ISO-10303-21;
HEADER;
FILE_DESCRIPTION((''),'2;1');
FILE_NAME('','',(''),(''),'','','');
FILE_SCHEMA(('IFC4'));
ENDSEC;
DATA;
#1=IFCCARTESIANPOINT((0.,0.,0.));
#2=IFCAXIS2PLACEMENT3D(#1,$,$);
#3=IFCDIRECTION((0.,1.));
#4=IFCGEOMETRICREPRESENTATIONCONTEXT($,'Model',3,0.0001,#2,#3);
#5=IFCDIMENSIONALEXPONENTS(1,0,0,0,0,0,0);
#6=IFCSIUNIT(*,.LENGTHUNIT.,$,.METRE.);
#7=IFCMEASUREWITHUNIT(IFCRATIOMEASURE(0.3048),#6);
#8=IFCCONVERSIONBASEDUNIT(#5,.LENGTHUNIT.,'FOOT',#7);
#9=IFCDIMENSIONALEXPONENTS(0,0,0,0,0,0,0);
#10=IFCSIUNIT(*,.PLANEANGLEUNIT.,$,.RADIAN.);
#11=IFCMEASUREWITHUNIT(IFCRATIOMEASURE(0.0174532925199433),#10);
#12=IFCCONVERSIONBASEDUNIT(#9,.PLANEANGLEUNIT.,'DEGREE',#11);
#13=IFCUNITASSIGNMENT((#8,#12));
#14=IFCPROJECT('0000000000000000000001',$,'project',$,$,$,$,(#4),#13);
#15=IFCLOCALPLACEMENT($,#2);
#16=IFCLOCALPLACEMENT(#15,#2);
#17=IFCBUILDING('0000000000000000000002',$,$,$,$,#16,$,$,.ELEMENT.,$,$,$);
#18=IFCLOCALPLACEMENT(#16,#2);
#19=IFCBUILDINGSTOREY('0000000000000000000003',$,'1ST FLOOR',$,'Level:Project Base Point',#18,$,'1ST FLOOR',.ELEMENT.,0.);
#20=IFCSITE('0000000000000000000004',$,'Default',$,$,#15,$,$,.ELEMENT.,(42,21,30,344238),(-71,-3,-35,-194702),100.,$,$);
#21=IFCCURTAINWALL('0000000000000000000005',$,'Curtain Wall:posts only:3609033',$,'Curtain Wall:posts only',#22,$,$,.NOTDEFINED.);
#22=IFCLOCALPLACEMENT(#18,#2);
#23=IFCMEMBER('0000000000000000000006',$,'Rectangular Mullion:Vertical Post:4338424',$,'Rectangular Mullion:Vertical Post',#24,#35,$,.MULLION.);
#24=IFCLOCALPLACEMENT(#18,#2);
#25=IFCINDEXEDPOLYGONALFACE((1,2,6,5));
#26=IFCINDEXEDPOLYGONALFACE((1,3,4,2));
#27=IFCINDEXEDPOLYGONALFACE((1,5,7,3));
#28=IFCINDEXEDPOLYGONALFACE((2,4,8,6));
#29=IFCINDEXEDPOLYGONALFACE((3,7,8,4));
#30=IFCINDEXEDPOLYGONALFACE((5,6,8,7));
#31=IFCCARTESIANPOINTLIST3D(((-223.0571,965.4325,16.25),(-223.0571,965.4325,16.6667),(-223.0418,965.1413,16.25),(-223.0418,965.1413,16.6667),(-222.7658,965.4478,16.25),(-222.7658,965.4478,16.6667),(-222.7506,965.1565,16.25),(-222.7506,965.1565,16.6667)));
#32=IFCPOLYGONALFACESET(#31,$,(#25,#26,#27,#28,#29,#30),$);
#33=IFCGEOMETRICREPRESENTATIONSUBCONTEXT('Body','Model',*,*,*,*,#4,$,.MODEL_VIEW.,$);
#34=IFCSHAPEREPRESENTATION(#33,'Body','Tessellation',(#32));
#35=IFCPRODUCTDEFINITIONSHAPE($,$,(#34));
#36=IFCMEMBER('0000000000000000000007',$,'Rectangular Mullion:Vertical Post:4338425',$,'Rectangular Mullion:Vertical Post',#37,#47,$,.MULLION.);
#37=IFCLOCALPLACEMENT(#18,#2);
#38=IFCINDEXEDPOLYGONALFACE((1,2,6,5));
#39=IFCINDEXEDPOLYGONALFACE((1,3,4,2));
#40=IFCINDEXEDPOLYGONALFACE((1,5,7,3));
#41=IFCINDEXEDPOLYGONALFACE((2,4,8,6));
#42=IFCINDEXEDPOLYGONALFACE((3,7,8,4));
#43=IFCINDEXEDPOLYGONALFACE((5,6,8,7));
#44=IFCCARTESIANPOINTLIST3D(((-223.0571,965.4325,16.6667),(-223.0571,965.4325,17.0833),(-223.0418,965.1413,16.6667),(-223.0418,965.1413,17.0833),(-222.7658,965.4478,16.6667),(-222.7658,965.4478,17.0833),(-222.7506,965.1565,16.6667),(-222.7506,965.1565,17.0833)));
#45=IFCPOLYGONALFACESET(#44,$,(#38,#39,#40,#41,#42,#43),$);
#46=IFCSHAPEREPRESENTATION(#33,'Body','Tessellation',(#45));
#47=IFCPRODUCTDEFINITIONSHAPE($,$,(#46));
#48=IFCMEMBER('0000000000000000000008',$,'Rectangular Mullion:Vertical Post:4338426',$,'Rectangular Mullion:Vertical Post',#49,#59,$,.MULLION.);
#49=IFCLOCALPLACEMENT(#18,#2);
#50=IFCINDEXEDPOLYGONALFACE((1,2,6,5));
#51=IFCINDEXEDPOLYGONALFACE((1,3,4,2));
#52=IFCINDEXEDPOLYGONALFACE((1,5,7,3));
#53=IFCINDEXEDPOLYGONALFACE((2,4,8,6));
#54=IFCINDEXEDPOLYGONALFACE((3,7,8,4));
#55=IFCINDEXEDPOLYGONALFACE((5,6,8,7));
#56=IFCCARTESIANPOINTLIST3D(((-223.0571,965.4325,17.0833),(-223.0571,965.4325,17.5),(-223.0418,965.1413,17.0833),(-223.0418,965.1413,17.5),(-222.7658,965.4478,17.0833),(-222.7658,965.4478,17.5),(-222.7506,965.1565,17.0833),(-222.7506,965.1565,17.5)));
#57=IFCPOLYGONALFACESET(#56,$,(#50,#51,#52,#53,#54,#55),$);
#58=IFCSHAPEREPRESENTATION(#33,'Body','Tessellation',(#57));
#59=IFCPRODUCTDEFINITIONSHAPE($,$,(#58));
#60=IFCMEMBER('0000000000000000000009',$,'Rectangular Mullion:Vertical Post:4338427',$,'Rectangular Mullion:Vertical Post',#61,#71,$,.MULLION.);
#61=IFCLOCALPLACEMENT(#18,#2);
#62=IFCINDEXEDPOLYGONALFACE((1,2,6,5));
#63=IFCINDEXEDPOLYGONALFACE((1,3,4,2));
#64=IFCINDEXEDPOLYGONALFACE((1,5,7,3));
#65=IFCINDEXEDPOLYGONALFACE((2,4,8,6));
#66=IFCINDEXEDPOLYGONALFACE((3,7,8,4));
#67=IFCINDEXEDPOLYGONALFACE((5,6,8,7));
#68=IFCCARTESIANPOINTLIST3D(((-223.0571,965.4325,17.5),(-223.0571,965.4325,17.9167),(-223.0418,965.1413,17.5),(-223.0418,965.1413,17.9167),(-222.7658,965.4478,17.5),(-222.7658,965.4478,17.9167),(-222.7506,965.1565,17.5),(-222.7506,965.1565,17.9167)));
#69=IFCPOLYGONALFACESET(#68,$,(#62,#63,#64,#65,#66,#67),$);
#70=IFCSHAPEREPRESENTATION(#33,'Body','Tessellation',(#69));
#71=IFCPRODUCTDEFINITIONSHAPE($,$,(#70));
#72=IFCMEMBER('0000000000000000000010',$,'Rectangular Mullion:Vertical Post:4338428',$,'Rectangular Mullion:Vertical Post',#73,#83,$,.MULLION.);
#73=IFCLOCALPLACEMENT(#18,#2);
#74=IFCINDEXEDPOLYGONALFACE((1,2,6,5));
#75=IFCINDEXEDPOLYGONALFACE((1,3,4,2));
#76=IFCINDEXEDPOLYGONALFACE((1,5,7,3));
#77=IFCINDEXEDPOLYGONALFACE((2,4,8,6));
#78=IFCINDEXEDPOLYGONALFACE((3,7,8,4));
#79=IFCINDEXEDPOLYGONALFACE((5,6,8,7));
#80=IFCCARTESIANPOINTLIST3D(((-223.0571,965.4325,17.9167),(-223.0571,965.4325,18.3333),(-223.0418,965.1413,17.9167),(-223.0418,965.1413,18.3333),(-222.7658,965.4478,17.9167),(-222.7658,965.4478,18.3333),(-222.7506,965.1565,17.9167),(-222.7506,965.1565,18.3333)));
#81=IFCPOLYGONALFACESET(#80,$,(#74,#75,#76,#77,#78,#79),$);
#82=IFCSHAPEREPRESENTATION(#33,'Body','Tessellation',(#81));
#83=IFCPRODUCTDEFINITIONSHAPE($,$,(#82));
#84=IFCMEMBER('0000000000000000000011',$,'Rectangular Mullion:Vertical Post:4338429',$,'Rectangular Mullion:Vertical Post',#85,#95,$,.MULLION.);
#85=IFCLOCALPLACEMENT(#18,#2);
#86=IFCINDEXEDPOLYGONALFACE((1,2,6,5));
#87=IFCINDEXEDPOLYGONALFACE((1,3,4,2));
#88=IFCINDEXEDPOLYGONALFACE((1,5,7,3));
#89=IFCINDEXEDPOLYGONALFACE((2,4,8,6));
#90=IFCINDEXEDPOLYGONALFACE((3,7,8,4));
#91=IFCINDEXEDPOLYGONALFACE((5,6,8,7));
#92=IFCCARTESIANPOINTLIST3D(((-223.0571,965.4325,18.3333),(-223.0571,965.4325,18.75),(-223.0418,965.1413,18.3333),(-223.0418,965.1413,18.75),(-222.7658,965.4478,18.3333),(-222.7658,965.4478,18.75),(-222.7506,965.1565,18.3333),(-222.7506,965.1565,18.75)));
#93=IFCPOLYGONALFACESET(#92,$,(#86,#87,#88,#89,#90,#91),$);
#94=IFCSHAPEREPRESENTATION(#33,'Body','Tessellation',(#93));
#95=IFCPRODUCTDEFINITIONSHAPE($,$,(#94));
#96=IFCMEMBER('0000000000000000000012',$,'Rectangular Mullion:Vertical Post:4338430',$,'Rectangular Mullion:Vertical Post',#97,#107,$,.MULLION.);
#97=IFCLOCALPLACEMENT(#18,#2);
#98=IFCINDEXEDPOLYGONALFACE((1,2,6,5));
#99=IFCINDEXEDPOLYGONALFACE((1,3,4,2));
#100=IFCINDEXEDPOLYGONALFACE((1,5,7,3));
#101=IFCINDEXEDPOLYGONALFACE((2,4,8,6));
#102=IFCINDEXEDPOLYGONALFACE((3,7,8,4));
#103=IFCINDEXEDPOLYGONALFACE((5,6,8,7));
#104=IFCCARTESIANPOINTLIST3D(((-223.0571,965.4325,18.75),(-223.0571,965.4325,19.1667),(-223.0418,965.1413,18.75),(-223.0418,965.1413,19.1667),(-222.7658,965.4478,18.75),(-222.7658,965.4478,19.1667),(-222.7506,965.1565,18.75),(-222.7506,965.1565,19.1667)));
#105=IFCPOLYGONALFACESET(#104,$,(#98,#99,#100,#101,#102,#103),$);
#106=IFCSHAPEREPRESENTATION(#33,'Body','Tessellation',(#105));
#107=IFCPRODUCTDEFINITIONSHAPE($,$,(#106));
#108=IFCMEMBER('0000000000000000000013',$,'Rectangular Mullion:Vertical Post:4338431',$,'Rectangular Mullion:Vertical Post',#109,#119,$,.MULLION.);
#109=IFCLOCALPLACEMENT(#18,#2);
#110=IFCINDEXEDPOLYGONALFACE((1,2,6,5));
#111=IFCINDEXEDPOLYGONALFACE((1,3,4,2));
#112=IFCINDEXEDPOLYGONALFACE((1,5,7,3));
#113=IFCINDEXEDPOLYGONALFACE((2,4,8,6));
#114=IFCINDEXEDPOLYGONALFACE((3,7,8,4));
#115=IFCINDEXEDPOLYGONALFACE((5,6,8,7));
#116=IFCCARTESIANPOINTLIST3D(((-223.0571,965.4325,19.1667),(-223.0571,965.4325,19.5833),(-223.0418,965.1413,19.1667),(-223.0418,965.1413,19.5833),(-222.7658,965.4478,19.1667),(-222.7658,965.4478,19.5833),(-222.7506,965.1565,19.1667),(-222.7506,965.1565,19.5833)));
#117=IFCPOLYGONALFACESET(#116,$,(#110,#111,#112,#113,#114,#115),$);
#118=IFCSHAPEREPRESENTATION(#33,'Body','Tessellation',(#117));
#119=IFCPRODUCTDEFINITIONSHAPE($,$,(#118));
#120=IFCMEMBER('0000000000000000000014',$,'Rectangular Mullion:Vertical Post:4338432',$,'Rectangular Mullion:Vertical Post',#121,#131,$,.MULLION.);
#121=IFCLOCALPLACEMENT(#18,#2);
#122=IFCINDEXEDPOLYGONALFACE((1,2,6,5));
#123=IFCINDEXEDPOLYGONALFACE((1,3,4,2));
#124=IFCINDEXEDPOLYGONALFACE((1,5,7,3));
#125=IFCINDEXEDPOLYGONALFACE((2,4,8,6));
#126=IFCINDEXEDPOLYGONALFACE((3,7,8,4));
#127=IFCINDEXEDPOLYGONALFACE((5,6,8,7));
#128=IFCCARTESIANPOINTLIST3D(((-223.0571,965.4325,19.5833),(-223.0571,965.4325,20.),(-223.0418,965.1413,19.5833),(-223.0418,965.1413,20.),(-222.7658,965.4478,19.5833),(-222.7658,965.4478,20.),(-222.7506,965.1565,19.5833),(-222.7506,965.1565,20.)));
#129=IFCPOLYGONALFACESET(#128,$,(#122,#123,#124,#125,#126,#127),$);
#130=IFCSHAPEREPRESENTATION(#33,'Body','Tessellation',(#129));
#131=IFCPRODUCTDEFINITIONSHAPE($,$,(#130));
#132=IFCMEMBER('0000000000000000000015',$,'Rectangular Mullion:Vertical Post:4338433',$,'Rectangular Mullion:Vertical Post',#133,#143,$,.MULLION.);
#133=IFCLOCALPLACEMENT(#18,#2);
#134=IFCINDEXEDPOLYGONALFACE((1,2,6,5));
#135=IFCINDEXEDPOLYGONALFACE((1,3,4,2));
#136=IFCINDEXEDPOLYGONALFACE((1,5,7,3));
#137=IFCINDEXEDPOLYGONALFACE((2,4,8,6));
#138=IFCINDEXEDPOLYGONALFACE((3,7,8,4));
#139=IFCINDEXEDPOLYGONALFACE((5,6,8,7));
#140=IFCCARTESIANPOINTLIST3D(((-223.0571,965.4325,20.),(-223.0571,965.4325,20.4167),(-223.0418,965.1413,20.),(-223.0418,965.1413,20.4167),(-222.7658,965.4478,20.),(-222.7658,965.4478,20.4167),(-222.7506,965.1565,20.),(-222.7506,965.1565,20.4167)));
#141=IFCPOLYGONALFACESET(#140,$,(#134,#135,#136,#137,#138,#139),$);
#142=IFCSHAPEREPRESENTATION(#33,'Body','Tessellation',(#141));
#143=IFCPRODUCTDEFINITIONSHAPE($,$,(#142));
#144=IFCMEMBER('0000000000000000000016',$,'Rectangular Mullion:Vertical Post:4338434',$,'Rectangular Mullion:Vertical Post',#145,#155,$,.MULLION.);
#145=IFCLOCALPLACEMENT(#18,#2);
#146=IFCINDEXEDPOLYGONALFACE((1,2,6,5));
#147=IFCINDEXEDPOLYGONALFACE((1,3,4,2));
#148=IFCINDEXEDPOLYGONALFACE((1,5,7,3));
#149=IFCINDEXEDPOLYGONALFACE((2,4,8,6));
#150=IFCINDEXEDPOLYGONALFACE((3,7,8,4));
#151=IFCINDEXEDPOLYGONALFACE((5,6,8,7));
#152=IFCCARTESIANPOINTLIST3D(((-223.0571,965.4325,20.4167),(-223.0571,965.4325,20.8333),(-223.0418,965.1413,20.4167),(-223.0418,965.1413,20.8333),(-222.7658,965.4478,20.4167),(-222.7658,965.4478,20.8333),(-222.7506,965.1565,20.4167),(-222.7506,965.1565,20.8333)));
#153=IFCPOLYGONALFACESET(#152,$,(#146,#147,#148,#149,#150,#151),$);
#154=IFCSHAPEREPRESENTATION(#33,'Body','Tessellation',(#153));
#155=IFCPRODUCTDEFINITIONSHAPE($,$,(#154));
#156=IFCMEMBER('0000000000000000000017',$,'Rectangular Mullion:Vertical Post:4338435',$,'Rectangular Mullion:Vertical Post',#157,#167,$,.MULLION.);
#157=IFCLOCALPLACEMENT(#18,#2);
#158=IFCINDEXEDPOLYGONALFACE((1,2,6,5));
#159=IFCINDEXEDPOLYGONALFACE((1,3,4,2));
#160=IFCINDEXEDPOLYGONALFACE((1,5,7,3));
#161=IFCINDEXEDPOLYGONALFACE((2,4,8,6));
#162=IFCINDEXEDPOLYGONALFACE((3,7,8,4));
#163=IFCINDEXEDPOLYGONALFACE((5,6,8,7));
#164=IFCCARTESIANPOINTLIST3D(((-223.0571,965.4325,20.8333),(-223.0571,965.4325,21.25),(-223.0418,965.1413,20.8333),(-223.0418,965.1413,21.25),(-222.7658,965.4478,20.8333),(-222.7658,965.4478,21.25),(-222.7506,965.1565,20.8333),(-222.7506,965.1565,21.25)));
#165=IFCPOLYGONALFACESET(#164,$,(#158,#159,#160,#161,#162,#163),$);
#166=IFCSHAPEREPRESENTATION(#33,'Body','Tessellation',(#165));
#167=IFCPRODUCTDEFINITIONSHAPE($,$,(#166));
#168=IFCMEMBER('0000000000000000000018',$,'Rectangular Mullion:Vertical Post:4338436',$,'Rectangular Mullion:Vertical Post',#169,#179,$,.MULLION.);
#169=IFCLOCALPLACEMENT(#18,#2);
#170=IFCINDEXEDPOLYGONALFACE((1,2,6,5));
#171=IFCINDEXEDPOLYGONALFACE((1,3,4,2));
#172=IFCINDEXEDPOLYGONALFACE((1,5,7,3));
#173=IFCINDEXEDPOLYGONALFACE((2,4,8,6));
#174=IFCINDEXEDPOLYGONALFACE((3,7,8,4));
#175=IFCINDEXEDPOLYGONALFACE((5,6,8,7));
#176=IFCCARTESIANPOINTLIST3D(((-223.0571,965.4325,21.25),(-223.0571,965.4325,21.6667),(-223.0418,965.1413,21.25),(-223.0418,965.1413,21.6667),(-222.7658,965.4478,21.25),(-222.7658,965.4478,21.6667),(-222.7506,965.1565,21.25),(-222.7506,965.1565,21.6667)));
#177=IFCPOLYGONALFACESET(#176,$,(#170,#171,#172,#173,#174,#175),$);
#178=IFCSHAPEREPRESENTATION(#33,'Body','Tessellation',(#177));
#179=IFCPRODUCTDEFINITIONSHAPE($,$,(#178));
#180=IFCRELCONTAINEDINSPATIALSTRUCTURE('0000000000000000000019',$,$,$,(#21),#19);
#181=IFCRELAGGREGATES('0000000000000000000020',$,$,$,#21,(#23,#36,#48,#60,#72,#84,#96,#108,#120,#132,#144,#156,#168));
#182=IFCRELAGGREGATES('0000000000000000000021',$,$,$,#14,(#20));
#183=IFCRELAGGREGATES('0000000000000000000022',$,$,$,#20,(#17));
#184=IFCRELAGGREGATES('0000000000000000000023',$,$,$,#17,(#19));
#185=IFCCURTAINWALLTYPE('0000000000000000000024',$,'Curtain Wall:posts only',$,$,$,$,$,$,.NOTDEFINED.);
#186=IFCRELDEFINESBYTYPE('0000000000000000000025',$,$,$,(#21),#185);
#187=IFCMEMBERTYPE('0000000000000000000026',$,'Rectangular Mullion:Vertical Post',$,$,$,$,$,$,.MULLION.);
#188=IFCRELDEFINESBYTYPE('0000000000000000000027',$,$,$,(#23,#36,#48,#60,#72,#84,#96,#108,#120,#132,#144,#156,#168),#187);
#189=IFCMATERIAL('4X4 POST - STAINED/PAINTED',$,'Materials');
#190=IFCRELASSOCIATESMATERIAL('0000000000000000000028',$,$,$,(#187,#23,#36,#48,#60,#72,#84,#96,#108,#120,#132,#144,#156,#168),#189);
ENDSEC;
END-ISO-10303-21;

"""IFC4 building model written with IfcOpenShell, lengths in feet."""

from ifc_helpers import new_model, entity, si_unit, converted_unit, direction, frame, origin, origin_2d_with_axis, place, context, subcontext, project, spatial, rectangle, extrude, source, transform, mapped, material, material_profile, profile_set, profile_usage, type_object, type_shapes, element, aggregate, save


model = new_model("IFC4")

# Units and contexts
model_context = context("Model", 3, precision=0.0001, world=origin(), true_north=direction((0.0, 1.0)))
body_context = subcontext(model_context, "Body", "Model", "MODEL_VIEW")
ifc_project = project(units=[converted_unit("LENGTHUNIT", "FOOT", entity("IfcRatioMeasure", 0.3048), si_unit("LENGTHUNIT", "METRE"), dimensions=[1, 0, 0, 0, 0, 0, 0]), converted_unit("PLANEANGLEUNIT", "DEGREE", entity("IfcRatioMeasure", 0.0174532925199433), si_unit("PLANEANGLEUNIT", "RADIAN"), dimensions=[0, 0, 0, 0, 0, 0, 0])], contexts=[model_context])

# Site, building, storey
site_placement = place(None, origin())
site = spatial("IfcSite", under=ifc_project, at=site_placement, Name="Default", CompositionType="ELEMENT", RefLatitude=(42, 21, 30, 344238), RefLongitude=(-71, -3, -35, -194702), RefElevation=100.0)
building_placement = place(site_placement, origin())
building = spatial("IfcBuilding", under=site, at=building_placement, CompositionType="ELEMENT")
storey_placement = place(building_placement, origin())
storey = spatial("IfcBuildingStorey", under=building, at=storey_placement, Name="1ST FLOOR", ObjectType="Level:Project Base Point", LongName="1ST FLOOR", CompositionType="ELEMENT", Elevation=0.0)

# Curtain wall, members
curtain_wall_type_1 = type_object("IfcCurtainWallType", Name="Curtain Wall:posts only", PredefinedType="NOTDEFINED")
curtain_wall_1_placement = place(storey_placement, origin())
curtain_wall_1 = element("IfcCurtainWall", 1, at=curtain_wall_1_placement, inside=storey, type_object=curtain_wall_type_1, Name="Curtain Wall:posts only:3609033", ObjectType="Curtain Wall:posts only", PredefinedType="NOTDEFINED")
ifc_material_1 = material(Name="4X4 POST - STAINED/PAINTED", Category="Materials")
ifc_material_profile_1 = material_profile(ifc_material_1, rectangle(XDim=0.2917, YDim=0.2917, at=origin_2d_with_axis()), Name="Vertical Post")
ifc_profile_set_1 = profile_set([ifc_material_profile_1], Name="Vertical Post")
ifc_profile_usage_1 = profile_usage(ifc_profile_set_1)
member_type_1 = type_object("IfcMemberType", Name="Rectangular Mullion:Vertical Post", PredefinedType="MULLION", material=ifc_profile_set_1)
shared_shape_1 = source(origin(), body_context, "Body", "SweptSolid", [
    extrude(rectangle(XDim=0.2917, YDim=0.2917, at=origin_2d_with_axis()), frame((0.0, -0.2083, -0.4167), z_axis=(0.0, 0.0, 1.0), x_axis=(0.0, -1.0, 0.0)), (0.0, 0.0, 1.0), 0.4167),
])
type_shapes(member_type_1, [shared_shape_1])
member_1_placement = place(storey_placement, frame((-222.9147, 965.5026, 16.25), z_axis=(0.0, 0.0, -1.0), x_axis=(-0.99863, -0.052336, 0.0)))
member_1 = element("IfcMember", 2, at=member_1_placement, type_object=member_type_1, material=ifc_profile_usage_1, Name="Rectangular Mullion:Vertical Post:4338424", ObjectType="Rectangular Mullion:Vertical Post", PredefinedType="MULLION", context=body_context, shape_type="MappedRepresentation", body=[
    mapped(shared_shape_1, transform((0.0, 0.0, 0.0), scale=1.0)),
])
ifc_profile_usage_2 = profile_usage(ifc_profile_set_1)
member_2_placement = place(storey_placement, frame((-222.9147, 965.5026, 16.6667), z_axis=(0.0, 0.0, -1.0), x_axis=(-0.99863, -0.052336, 0.0)))
member_2 = element("IfcMember", 3, at=member_2_placement, type_object=member_type_1, material=ifc_profile_usage_2, Name="Rectangular Mullion:Vertical Post:4338425", ObjectType="Rectangular Mullion:Vertical Post", PredefinedType="MULLION", context=body_context, shape_type="MappedRepresentation", body=[
    mapped(shared_shape_1, transform((0.0, 0.0, 0.0), scale=1.0)),
])
ifc_profile_usage_3 = profile_usage(ifc_profile_set_1)
member_3_placement = place(storey_placement, frame((-222.9147, 965.5026, 17.0833), z_axis=(0.0, 0.0, -1.0), x_axis=(-0.99863, -0.052336, 0.0)))
member_3 = element("IfcMember", 4, at=member_3_placement, type_object=member_type_1, material=ifc_profile_usage_3, Name="Rectangular Mullion:Vertical Post:4338426", ObjectType="Rectangular Mullion:Vertical Post", PredefinedType="MULLION", context=body_context, shape_type="MappedRepresentation", body=[
    mapped(shared_shape_1, transform((0.0, 0.0, 0.0), scale=1.0)),
])
ifc_profile_usage_4 = profile_usage(ifc_profile_set_1)
member_4_placement = place(storey_placement, frame((-222.9147, 965.5026, 17.5), z_axis=(0.0, 0.0, -1.0), x_axis=(-0.99863, -0.052336, 0.0)))
member_4 = element("IfcMember", 5, at=member_4_placement, type_object=member_type_1, material=ifc_profile_usage_4, Name="Rectangular Mullion:Vertical Post:4338427", ObjectType="Rectangular Mullion:Vertical Post", PredefinedType="MULLION", context=body_context, shape_type="MappedRepresentation", body=[
    mapped(shared_shape_1, transform((0.0, 0.0, 0.0), scale=1.0)),
])
ifc_profile_usage_5 = profile_usage(ifc_profile_set_1)
member_5_placement = place(storey_placement, frame((-222.9147, 965.5026, 17.9167), z_axis=(0.0, 0.0, -1.0), x_axis=(-0.99863, -0.052336, 0.0)))
member_5 = element("IfcMember", 6, at=member_5_placement, type_object=member_type_1, material=ifc_profile_usage_5, Name="Rectangular Mullion:Vertical Post:4338428", ObjectType="Rectangular Mullion:Vertical Post", PredefinedType="MULLION", context=body_context, shape_type="MappedRepresentation", body=[
    mapped(shared_shape_1, transform((0.0, 0.0, 0.0), scale=1.0)),
])
ifc_profile_usage_6 = profile_usage(ifc_profile_set_1)
member_6_placement = place(storey_placement, frame((-222.9147, 965.5026, 18.3333), z_axis=(0.0, 0.0, -1.0), x_axis=(-0.99863, -0.052336, 0.0)))
member_6 = element("IfcMember", 7, at=member_6_placement, type_object=member_type_1, material=ifc_profile_usage_6, Name="Rectangular Mullion:Vertical Post:4338429", ObjectType="Rectangular Mullion:Vertical Post", PredefinedType="MULLION", context=body_context, shape_type="MappedRepresentation", body=[
    mapped(shared_shape_1, transform((0.0, 0.0, 0.0), scale=1.0)),
])
ifc_profile_usage_7 = profile_usage(ifc_profile_set_1)
member_7_placement = place(storey_placement, frame((-222.9147, 965.5026, 18.75), z_axis=(0.0, 0.0, -1.0), x_axis=(-0.99863, -0.052336, 0.0)))
member_7 = element("IfcMember", 8, at=member_7_placement, type_object=member_type_1, material=ifc_profile_usage_7, Name="Rectangular Mullion:Vertical Post:4338430", ObjectType="Rectangular Mullion:Vertical Post", PredefinedType="MULLION", context=body_context, shape_type="MappedRepresentation", body=[
    mapped(shared_shape_1, transform((0.0, 0.0, 0.0), scale=1.0)),
])
ifc_profile_usage_8 = profile_usage(ifc_profile_set_1)
member_8_placement = place(storey_placement, frame((-222.9147, 965.5026, 19.1667), z_axis=(0.0, 0.0, -1.0), x_axis=(-0.99863, -0.052336, 0.0)))
member_8 = element("IfcMember", 9, at=member_8_placement, type_object=member_type_1, material=ifc_profile_usage_8, Name="Rectangular Mullion:Vertical Post:4338431", ObjectType="Rectangular Mullion:Vertical Post", PredefinedType="MULLION", context=body_context, shape_type="MappedRepresentation", body=[
    mapped(shared_shape_1, transform((0.0, 0.0, 0.0), scale=1.0)),
])
ifc_profile_usage_9 = profile_usage(ifc_profile_set_1)
member_9_placement = place(storey_placement, frame((-222.9147, 965.5026, 19.5833), z_axis=(0.0, 0.0, -1.0), x_axis=(-0.99863, -0.052336, 0.0)))
member_9 = element("IfcMember", 10, at=member_9_placement, type_object=member_type_1, material=ifc_profile_usage_9, Name="Rectangular Mullion:Vertical Post:4338432", ObjectType="Rectangular Mullion:Vertical Post", PredefinedType="MULLION", context=body_context, shape_type="MappedRepresentation", body=[
    mapped(shared_shape_1, transform((0.0, 0.0, 0.0), scale=1.0)),
])
ifc_profile_usage_10 = profile_usage(ifc_profile_set_1)
member_10_placement = place(storey_placement, frame((-222.9147, 965.5026, 20.0), z_axis=(0.0, 0.0, -1.0), x_axis=(-0.99863, -0.052336, 0.0)))
member_10 = element("IfcMember", 11, at=member_10_placement, type_object=member_type_1, material=ifc_profile_usage_10, Name="Rectangular Mullion:Vertical Post:4338433", ObjectType="Rectangular Mullion:Vertical Post", PredefinedType="MULLION", context=body_context, shape_type="MappedRepresentation", body=[
    mapped(shared_shape_1, transform((0.0, 0.0, 0.0), scale=1.0)),
])
ifc_profile_usage_11 = profile_usage(ifc_profile_set_1)
member_11_placement = place(storey_placement, frame((-222.9147, 965.5026, 20.4167), z_axis=(0.0, 0.0, -1.0), x_axis=(-0.99863, -0.052336, 0.0)))
member_11 = element("IfcMember", 12, at=member_11_placement, type_object=member_type_1, material=ifc_profile_usage_11, Name="Rectangular Mullion:Vertical Post:4338434", ObjectType="Rectangular Mullion:Vertical Post", PredefinedType="MULLION", context=body_context, shape_type="MappedRepresentation", body=[
    mapped(shared_shape_1, transform((0.0, 0.0, 0.0), scale=1.0)),
])
ifc_profile_usage_12 = profile_usage(ifc_profile_set_1)
member_12_placement = place(storey_placement, frame((-222.9147, 965.5026, 20.8333), z_axis=(0.0, 0.0, -1.0), x_axis=(-0.99863, -0.052336, 0.0)))
member_12 = element("IfcMember", 13, at=member_12_placement, type_object=member_type_1, material=ifc_profile_usage_12, Name="Rectangular Mullion:Vertical Post:4338435", ObjectType="Rectangular Mullion:Vertical Post", PredefinedType="MULLION", context=body_context, shape_type="MappedRepresentation", body=[
    mapped(shared_shape_1, transform((0.0, 0.0, 0.0), scale=1.0)),
])
ifc_profile_usage_13 = profile_usage(ifc_profile_set_1)
member_13_placement = place(storey_placement, frame((-222.9147, 965.5026, 21.25), z_axis=(0.0, 0.0, -1.0), x_axis=(-0.99863, -0.052336, 0.0)))
member_13 = element("IfcMember", 14, at=member_13_placement, type_object=member_type_1, material=ifc_profile_usage_13, Name="Rectangular Mullion:Vertical Post:4338436", ObjectType="Rectangular Mullion:Vertical Post", PredefinedType="MULLION", context=body_context, shape_type="MappedRepresentation", body=[
    mapped(shared_shape_1, transform((0.0, 0.0, 0.0), scale=1.0)),
])
aggregate(curtain_wall_1, [member_1, member_2, member_3, member_4, member_5, member_6, member_7, member_8, member_9, member_10, member_11, member_12, member_13])

save(model, "model.ifc")
